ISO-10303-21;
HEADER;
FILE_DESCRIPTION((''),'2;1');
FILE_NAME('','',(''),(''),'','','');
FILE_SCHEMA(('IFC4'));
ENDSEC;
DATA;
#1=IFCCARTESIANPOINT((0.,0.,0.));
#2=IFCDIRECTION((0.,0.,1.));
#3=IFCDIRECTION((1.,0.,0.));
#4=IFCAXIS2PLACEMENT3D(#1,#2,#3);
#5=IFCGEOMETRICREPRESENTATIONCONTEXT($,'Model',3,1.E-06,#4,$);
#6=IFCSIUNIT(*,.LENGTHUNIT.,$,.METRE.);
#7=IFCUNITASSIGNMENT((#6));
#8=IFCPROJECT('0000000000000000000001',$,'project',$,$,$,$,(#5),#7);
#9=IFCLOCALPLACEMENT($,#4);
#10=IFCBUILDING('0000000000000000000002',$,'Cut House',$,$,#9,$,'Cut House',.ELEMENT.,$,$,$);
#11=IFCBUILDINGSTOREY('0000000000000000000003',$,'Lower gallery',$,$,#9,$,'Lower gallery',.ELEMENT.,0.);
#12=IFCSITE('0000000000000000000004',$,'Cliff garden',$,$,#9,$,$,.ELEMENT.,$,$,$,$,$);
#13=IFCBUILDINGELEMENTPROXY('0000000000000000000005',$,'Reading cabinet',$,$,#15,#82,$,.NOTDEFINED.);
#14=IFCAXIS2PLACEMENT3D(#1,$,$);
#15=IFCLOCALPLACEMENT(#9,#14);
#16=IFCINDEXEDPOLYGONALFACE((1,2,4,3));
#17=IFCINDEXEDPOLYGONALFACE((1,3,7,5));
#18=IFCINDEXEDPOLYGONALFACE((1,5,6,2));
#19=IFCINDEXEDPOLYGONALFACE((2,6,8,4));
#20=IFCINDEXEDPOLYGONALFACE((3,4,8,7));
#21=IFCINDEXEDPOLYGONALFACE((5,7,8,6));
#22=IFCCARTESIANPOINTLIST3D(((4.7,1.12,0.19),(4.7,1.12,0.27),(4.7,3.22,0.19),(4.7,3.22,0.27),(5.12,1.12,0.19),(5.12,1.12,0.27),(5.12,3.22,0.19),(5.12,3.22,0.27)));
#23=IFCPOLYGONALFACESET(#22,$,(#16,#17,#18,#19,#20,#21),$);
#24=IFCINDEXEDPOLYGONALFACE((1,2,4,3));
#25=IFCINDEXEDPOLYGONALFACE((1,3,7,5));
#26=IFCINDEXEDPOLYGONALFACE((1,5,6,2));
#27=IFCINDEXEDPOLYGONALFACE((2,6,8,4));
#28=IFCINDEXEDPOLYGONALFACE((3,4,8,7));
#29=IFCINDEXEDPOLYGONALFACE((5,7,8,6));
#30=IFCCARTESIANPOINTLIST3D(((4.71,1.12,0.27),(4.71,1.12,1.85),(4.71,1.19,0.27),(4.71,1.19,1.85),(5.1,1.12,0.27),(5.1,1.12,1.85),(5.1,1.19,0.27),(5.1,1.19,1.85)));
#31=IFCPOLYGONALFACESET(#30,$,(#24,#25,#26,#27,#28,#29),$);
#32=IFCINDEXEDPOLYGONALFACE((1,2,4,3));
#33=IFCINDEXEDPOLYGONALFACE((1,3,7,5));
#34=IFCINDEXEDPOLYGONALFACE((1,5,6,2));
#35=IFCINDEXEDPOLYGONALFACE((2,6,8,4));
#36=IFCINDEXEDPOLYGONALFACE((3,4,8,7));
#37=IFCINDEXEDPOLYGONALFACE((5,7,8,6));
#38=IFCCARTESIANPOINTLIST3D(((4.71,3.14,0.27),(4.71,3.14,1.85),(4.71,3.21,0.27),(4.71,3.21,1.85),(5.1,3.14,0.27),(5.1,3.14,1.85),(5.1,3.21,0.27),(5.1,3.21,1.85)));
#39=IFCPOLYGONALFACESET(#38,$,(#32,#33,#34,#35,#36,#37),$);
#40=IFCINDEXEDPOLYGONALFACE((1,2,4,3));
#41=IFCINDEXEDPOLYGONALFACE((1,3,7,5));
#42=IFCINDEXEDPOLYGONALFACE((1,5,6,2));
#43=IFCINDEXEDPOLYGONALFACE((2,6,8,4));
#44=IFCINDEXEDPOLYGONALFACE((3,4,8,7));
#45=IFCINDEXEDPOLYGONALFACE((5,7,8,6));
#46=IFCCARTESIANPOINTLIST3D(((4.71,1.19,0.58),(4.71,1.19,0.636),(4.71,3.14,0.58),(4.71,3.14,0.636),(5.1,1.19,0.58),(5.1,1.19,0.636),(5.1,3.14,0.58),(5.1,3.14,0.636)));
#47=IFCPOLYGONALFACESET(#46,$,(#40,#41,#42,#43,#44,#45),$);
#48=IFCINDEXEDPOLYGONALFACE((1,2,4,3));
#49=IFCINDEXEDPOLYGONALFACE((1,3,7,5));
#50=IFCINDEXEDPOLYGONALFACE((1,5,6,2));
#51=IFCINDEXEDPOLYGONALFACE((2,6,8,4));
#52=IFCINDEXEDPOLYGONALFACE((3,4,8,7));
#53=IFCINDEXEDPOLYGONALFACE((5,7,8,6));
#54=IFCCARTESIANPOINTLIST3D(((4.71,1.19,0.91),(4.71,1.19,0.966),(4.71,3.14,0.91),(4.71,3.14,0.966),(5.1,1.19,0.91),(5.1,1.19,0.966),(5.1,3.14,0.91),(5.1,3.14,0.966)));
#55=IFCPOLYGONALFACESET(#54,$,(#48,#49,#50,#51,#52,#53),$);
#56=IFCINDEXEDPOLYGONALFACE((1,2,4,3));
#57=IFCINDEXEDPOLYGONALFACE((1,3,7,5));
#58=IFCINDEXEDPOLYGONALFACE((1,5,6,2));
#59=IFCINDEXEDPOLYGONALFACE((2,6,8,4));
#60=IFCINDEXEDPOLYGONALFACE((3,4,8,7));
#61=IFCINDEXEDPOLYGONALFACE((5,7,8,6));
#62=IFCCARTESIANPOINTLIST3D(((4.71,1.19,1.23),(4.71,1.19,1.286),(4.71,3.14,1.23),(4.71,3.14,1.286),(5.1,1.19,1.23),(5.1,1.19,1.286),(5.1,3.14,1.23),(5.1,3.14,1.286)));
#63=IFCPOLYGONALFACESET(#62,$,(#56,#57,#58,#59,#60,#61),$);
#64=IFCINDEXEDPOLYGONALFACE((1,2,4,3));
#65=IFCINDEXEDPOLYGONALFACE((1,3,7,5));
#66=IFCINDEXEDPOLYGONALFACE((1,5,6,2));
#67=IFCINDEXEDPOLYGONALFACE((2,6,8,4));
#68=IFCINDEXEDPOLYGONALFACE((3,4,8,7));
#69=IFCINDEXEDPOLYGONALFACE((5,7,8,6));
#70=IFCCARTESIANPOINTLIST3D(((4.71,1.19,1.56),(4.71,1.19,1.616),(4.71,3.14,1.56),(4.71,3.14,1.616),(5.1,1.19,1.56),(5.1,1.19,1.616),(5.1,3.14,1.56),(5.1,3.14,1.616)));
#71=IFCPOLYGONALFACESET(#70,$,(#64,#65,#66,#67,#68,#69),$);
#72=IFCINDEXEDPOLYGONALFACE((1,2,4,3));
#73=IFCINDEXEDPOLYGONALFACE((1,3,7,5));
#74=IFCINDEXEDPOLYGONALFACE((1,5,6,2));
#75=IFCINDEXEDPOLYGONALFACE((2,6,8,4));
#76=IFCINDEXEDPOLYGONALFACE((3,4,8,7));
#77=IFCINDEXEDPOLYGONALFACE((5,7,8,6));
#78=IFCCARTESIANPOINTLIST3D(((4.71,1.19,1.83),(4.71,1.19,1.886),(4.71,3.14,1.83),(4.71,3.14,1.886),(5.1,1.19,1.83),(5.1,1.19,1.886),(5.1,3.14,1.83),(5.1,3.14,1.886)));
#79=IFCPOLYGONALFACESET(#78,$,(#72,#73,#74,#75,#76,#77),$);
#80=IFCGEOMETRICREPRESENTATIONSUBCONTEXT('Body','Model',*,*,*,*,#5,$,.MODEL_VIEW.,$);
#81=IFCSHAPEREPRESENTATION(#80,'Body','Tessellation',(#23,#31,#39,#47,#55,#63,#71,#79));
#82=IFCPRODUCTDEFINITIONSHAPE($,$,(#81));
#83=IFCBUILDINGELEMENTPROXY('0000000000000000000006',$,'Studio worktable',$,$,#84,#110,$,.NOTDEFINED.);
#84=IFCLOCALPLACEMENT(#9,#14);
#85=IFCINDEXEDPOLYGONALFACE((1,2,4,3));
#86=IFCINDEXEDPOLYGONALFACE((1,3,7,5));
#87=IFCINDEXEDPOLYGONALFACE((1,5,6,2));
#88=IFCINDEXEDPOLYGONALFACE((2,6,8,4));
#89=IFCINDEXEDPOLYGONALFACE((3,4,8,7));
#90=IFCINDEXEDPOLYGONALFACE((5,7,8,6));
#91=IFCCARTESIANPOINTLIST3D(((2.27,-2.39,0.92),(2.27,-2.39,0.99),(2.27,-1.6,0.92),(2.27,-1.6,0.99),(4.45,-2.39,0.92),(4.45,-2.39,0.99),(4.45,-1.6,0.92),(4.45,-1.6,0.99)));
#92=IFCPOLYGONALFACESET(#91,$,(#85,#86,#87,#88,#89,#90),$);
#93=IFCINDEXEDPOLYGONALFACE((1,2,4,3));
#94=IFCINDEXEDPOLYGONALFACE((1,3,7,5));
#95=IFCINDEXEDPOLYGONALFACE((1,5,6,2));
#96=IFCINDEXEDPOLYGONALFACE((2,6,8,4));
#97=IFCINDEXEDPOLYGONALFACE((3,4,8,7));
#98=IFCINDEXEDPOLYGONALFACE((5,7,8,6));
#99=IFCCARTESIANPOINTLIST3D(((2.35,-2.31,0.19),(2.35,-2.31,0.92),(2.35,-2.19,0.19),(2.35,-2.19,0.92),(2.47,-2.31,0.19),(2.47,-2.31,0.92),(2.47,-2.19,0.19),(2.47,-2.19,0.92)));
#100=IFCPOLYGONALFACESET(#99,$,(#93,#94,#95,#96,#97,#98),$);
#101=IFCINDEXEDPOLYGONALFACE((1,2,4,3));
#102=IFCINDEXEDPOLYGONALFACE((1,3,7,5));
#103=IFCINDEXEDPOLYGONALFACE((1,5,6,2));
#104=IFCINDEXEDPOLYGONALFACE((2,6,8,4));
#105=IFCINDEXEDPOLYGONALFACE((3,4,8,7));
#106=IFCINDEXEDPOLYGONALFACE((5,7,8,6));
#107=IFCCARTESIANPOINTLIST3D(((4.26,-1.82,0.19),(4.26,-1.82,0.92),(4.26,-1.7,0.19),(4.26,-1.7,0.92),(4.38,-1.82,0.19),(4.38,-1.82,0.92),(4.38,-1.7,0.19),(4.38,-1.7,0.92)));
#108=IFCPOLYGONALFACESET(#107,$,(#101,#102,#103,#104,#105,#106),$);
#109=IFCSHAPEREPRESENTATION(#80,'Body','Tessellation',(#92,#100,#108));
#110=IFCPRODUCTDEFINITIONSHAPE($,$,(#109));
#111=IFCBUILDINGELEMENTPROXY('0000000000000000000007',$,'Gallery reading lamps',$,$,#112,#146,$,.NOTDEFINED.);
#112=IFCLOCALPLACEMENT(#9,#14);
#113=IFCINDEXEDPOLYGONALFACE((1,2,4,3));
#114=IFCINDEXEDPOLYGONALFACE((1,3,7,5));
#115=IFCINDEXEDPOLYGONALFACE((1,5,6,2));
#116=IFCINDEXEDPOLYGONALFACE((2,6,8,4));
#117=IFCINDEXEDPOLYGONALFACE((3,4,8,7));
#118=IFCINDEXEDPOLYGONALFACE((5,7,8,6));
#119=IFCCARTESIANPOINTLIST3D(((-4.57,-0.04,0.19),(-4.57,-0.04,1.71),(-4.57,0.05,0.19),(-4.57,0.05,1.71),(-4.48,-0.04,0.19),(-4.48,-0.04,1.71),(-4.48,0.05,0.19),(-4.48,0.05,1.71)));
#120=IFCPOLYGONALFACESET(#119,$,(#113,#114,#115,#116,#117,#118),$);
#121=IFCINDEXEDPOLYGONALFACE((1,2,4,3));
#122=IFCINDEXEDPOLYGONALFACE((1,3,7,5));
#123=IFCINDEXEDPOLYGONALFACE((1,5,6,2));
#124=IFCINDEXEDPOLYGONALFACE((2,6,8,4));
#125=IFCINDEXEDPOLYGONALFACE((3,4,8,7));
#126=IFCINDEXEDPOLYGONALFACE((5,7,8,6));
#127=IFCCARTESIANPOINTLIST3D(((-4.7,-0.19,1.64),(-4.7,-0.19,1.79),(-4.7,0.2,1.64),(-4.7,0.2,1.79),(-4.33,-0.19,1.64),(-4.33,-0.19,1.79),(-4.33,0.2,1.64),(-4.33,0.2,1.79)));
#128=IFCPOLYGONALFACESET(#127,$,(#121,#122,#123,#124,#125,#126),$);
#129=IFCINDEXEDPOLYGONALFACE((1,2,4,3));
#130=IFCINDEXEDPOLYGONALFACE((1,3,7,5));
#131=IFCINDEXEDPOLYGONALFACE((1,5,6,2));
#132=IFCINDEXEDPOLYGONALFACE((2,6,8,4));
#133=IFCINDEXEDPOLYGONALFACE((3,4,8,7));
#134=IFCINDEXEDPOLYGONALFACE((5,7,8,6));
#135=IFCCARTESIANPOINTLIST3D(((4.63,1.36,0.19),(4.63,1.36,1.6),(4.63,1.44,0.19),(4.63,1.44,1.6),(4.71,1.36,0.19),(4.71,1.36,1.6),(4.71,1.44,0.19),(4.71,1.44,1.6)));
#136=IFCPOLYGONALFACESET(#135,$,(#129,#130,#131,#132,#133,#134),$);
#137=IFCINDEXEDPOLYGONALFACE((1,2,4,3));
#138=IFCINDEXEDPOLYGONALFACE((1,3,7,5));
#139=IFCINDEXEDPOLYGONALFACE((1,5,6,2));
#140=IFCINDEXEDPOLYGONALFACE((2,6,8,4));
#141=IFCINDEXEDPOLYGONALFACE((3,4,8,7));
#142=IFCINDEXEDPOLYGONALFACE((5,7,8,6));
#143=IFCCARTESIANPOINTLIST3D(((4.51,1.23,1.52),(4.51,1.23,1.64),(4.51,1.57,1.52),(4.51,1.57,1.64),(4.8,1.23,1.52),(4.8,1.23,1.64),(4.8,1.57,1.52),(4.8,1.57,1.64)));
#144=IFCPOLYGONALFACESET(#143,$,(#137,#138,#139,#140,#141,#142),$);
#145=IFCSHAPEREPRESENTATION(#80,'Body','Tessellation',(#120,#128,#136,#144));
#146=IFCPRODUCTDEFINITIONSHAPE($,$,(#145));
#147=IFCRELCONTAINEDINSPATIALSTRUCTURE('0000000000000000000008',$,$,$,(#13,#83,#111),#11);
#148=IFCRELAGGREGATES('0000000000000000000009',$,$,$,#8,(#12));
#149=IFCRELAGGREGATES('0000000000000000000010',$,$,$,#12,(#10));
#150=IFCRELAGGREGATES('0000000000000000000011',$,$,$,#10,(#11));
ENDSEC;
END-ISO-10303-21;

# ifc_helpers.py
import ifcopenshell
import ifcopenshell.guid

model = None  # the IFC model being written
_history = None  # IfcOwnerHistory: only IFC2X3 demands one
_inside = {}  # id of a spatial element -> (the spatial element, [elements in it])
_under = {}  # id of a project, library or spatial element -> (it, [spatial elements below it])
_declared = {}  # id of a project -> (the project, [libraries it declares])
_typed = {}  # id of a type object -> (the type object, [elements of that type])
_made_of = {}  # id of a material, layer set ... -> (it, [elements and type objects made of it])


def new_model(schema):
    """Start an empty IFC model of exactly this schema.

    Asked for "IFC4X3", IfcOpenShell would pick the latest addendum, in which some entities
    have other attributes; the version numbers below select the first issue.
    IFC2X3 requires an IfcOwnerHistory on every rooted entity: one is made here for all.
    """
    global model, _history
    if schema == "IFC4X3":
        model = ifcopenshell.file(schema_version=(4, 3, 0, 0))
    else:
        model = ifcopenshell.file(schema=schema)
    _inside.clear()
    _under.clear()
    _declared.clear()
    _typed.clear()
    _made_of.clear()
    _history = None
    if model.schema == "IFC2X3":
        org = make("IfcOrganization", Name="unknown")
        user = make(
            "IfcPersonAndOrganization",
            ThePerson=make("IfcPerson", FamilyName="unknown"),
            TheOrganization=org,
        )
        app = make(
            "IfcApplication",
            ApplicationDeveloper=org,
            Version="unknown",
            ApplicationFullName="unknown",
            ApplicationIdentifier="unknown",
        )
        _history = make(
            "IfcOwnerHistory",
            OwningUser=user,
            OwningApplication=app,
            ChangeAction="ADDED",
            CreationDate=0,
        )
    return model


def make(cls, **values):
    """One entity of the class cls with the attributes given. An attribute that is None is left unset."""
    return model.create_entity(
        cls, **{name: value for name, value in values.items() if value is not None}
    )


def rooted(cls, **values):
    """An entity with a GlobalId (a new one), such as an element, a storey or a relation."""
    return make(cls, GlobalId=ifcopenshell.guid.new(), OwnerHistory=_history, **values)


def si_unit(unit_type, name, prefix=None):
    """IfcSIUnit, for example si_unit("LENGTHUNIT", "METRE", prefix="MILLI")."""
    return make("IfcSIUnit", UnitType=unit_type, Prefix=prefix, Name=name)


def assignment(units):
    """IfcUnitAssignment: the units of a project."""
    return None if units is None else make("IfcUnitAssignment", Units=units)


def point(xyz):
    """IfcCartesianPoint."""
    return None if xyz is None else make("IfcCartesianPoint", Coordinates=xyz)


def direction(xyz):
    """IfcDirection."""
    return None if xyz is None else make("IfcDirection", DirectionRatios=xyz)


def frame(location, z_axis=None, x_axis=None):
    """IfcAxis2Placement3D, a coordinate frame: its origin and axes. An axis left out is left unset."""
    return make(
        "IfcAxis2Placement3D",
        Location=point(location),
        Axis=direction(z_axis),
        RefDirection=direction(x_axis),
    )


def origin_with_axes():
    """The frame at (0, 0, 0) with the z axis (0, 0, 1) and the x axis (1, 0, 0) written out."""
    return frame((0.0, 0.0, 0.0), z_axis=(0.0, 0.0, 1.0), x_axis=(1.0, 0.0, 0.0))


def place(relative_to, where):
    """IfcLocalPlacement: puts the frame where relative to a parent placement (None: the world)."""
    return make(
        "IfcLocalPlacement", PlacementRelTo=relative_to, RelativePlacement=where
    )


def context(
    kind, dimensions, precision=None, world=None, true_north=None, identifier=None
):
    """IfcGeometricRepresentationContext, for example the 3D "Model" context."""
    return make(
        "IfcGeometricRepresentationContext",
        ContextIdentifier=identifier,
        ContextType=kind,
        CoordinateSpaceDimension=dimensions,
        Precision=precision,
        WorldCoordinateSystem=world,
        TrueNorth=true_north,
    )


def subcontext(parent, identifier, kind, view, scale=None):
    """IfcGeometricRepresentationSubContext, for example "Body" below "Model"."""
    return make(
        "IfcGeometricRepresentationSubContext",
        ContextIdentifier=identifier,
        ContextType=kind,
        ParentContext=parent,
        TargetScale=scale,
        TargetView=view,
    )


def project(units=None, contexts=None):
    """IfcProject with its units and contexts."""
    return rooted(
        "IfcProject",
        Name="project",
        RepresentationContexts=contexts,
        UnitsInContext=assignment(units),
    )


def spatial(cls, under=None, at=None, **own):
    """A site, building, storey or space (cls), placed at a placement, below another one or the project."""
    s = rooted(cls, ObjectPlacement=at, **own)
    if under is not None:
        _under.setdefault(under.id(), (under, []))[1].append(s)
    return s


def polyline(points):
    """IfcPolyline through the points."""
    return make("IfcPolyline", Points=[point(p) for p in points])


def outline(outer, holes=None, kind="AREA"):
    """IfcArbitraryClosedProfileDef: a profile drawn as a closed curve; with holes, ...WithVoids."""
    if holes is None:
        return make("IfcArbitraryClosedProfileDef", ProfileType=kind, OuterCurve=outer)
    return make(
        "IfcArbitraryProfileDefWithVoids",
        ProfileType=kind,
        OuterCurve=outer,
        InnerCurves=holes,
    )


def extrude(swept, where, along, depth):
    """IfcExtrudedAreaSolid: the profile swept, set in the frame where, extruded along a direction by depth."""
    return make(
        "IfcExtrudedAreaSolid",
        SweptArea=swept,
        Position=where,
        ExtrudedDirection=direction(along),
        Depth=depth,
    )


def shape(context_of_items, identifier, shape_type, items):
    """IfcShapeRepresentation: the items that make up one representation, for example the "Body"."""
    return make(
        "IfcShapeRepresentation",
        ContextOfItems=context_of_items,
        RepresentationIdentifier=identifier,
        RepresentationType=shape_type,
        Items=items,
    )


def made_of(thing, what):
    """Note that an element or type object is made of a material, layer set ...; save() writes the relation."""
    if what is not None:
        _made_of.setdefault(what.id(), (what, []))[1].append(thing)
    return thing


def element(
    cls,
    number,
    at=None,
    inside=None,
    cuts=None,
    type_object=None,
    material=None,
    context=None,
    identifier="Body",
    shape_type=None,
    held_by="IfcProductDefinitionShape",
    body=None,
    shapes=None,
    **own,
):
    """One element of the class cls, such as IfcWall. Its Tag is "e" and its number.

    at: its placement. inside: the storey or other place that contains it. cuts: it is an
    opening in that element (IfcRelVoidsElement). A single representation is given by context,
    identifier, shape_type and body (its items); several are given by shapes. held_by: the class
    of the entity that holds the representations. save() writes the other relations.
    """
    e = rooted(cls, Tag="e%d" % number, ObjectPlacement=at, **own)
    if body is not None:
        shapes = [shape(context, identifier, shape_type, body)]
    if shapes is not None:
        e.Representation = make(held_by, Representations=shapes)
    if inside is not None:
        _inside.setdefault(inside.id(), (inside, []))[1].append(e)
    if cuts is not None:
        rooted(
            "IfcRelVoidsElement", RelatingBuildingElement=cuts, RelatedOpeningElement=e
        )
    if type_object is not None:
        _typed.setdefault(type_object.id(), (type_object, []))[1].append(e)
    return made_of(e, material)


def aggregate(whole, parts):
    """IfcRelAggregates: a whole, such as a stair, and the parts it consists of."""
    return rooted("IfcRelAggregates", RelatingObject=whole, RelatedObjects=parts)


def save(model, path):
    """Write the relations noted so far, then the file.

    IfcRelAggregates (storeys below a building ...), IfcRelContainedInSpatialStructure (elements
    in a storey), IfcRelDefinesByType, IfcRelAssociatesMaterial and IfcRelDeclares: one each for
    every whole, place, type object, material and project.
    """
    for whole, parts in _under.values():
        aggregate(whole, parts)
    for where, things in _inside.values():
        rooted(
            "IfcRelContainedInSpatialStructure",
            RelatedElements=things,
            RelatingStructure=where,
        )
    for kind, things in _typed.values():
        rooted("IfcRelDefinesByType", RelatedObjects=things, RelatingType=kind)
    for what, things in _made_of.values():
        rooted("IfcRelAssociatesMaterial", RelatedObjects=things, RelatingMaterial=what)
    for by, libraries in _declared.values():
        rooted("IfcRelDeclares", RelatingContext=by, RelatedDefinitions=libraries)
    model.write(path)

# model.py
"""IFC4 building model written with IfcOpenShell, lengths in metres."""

from ifc_helpers import new_model, si_unit, frame, origin_with_axes, place, context, subcontext, project, spatial, polyline, outline, extrude, element, save


model = new_model("IFC4")

# Units and contexts
model_context = context("Model", 3, precision=1e-06, world=origin_with_axes())
body_context = subcontext(model_context, "Body", "Model", "MODEL_VIEW")
ifc_project = project(units=[si_unit("LENGTHUNIT", "METRE")], contexts=[model_context])

# Site, building, storey
placement = place(None, origin_with_axes())
site = spatial("IfcSite", under=ifc_project, at=placement, Name="Cliff garden", CompositionType="ELEMENT")
building = spatial("IfcBuilding", under=site, at=placement, Name="Cut House", LongName="Cut House", CompositionType="ELEMENT")
storey = spatial("IfcBuildingStorey", under=building, at=placement, Name="Lower gallery", LongName="Lower gallery", CompositionType="ELEMENT", Elevation=0.0)

# Building element proxies
element("IfcBuildingElementProxy", 1, at=placement, inside=storey, Name="Reading cabinet", PredefinedType="NOTDEFINED", context=body_context, shape_type="SweptSolid", body=[
    extrude(outline(polyline([(0.0, 0.0), (0.42, 0.0), (0.42, 2.1), (0.0, 2.1), (0.0, 0.0)])), frame((4.7, 1.12, 0.19), z_axis=(0.0, 0.0, 1.0), x_axis=(1.0, 0.0, 0.0)), (0.0, 0.0, 1.0), 0.08),
    extrude(outline(polyline([(0.0, 0.0), (0.39, 0.0), (0.39, 0.07), (0.0, 0.07), (0.0, 0.0)])), frame((4.71, 1.12, 0.27), z_axis=(0.0, 0.0, 1.0), x_axis=(1.0, 0.0, 0.0)), (0.0, 0.0, 1.0), 1.58),
    extrude(outline(polyline([(0.0, 0.0), (0.39, 0.0), (0.39, 0.07), (0.0, 0.07), (0.0, 0.0)])), frame((4.71, 3.14, 0.27), z_axis=(0.0, 0.0, 1.0), x_axis=(1.0, 0.0, 0.0)), (0.0, 0.0, 1.0), 1.58),
    extrude(outline(polyline([(0.0, 0.0), (0.39, 0.0), (0.39, 1.95), (0.0, 1.95), (0.0, 0.0)])), frame((4.71, 1.19, 0.58), z_axis=(0.0, 0.0, 1.0), x_axis=(1.0, 0.0, 0.0)), (0.0, 0.0, 1.0), 0.056),
    extrude(outline(polyline([(0.0, 0.0), (0.39, 0.0), (0.39, 1.95), (0.0, 1.95), (0.0, 0.0)])), frame((4.71, 1.19, 0.91), z_axis=(0.0, 0.0, 1.0), x_axis=(1.0, 0.0, 0.0)), (0.0, 0.0, 1.0), 0.056),
    extrude(outline(polyline([(0.0, 0.0), (0.39, 0.0), (0.39, 1.95), (0.0, 1.95), (0.0, 0.0)])), frame((4.71, 1.19, 1.23), z_axis=(0.0, 0.0, 1.0), x_axis=(1.0, 0.0, 0.0)), (0.0, 0.0, 1.0), 0.056),
    extrude(outline(polyline([(0.0, 0.0), (0.39, 0.0), (0.39, 1.95), (0.0, 1.95), (0.0, 0.0)])), frame((4.71, 1.19, 1.56), z_axis=(0.0, 0.0, 1.0), x_axis=(1.0, 0.0, 0.0)), (0.0, 0.0, 1.0), 0.056),
    extrude(outline(polyline([(0.0, 0.0), (0.39, 0.0), (0.39, 1.95), (0.0, 1.95), (0.0, 0.0)])), frame((4.71, 1.19, 1.83), z_axis=(0.0, 0.0, 1.0), x_axis=(1.0, 0.0, 0.0)), (0.0, 0.0, 1.0), 0.056),
])
element("IfcBuildingElementProxy", 2, at=placement, inside=storey, Name="Studio worktable", PredefinedType="NOTDEFINED", context=body_context, shape_type="SweptSolid", body=[
    extrude(outline(polyline([(0.0, 0.0), (2.18, 0.0), (2.18, 0.79), (0.0, 0.79), (0.0, 0.0)])), frame((2.27, -2.39, 0.92), z_axis=(0.0, 0.0, 1.0), x_axis=(1.0, 0.0, 0.0)), (0.0, 0.0, 1.0), 0.07),
    extrude(outline(polyline([(0.0, 0.0), (0.12, 0.0), (0.12, 0.12), (0.0, 0.12), (0.0, 0.0)])), frame((2.35, -2.31, 0.19), z_axis=(0.0, 0.0, 1.0), x_axis=(1.0, 0.0, 0.0)), (0.0, 0.0, 1.0), 0.73),
    extrude(outline(polyline([(0.0, 0.0), (0.12, 0.0), (0.12, 0.12), (0.0, 0.12), (0.0, 0.0)])), frame((4.26, -1.82, 0.19), z_axis=(0.0, 0.0, 1.0), x_axis=(1.0, 0.0, 0.0)), (0.0, 0.0, 1.0), 0.73),
])
element("IfcBuildingElementProxy", 3, at=placement, inside=storey, Name="Gallery reading lamps", PredefinedType="NOTDEFINED", context=body_context, shape_type="SweptSolid", body=[
    extrude(outline(polyline([(0.0, 0.0), (0.09, 0.0), (0.09, 0.09), (0.0, 0.09), (0.0, 0.0)])), frame((-4.57, -0.04, 0.19), z_axis=(0.0, 0.0, 1.0), x_axis=(1.0, 0.0, 0.0)), (0.0, 0.0, 1.0), 1.52),
    extrude(outline(polyline([(0.0, 0.0), (0.37, 0.0), (0.37, 0.39), (0.0, 0.39), (0.0, 0.0)])), frame((-4.7, -0.19, 1.64), z_axis=(0.0, 0.0, 1.0), x_axis=(1.0, 0.0, 0.0)), (0.0, 0.0, 1.0), 0.15),
    extrude(outline(polyline([(0.0, 0.0), (0.08, 0.0), (0.08, 0.08), (0.0, 0.08), (0.0, 0.0)])), frame((4.63, 1.36, 0.19), z_axis=(0.0, 0.0, 1.0), x_axis=(1.0, 0.0, 0.0)), (0.0, 0.0, 1.0), 1.41),
    extrude(outline(polyline([(0.0, 0.0), (0.29, 0.0), (0.29, 0.34), (0.0, 0.34), (0.0, 0.0)])), frame((4.51, 1.23, 1.52), z_axis=(0.0, 0.0, 1.0), x_axis=(1.0, 0.0, 0.0)), (0.0, 0.0, 1.0), 0.12),
])

save(model, "model.ifc")
